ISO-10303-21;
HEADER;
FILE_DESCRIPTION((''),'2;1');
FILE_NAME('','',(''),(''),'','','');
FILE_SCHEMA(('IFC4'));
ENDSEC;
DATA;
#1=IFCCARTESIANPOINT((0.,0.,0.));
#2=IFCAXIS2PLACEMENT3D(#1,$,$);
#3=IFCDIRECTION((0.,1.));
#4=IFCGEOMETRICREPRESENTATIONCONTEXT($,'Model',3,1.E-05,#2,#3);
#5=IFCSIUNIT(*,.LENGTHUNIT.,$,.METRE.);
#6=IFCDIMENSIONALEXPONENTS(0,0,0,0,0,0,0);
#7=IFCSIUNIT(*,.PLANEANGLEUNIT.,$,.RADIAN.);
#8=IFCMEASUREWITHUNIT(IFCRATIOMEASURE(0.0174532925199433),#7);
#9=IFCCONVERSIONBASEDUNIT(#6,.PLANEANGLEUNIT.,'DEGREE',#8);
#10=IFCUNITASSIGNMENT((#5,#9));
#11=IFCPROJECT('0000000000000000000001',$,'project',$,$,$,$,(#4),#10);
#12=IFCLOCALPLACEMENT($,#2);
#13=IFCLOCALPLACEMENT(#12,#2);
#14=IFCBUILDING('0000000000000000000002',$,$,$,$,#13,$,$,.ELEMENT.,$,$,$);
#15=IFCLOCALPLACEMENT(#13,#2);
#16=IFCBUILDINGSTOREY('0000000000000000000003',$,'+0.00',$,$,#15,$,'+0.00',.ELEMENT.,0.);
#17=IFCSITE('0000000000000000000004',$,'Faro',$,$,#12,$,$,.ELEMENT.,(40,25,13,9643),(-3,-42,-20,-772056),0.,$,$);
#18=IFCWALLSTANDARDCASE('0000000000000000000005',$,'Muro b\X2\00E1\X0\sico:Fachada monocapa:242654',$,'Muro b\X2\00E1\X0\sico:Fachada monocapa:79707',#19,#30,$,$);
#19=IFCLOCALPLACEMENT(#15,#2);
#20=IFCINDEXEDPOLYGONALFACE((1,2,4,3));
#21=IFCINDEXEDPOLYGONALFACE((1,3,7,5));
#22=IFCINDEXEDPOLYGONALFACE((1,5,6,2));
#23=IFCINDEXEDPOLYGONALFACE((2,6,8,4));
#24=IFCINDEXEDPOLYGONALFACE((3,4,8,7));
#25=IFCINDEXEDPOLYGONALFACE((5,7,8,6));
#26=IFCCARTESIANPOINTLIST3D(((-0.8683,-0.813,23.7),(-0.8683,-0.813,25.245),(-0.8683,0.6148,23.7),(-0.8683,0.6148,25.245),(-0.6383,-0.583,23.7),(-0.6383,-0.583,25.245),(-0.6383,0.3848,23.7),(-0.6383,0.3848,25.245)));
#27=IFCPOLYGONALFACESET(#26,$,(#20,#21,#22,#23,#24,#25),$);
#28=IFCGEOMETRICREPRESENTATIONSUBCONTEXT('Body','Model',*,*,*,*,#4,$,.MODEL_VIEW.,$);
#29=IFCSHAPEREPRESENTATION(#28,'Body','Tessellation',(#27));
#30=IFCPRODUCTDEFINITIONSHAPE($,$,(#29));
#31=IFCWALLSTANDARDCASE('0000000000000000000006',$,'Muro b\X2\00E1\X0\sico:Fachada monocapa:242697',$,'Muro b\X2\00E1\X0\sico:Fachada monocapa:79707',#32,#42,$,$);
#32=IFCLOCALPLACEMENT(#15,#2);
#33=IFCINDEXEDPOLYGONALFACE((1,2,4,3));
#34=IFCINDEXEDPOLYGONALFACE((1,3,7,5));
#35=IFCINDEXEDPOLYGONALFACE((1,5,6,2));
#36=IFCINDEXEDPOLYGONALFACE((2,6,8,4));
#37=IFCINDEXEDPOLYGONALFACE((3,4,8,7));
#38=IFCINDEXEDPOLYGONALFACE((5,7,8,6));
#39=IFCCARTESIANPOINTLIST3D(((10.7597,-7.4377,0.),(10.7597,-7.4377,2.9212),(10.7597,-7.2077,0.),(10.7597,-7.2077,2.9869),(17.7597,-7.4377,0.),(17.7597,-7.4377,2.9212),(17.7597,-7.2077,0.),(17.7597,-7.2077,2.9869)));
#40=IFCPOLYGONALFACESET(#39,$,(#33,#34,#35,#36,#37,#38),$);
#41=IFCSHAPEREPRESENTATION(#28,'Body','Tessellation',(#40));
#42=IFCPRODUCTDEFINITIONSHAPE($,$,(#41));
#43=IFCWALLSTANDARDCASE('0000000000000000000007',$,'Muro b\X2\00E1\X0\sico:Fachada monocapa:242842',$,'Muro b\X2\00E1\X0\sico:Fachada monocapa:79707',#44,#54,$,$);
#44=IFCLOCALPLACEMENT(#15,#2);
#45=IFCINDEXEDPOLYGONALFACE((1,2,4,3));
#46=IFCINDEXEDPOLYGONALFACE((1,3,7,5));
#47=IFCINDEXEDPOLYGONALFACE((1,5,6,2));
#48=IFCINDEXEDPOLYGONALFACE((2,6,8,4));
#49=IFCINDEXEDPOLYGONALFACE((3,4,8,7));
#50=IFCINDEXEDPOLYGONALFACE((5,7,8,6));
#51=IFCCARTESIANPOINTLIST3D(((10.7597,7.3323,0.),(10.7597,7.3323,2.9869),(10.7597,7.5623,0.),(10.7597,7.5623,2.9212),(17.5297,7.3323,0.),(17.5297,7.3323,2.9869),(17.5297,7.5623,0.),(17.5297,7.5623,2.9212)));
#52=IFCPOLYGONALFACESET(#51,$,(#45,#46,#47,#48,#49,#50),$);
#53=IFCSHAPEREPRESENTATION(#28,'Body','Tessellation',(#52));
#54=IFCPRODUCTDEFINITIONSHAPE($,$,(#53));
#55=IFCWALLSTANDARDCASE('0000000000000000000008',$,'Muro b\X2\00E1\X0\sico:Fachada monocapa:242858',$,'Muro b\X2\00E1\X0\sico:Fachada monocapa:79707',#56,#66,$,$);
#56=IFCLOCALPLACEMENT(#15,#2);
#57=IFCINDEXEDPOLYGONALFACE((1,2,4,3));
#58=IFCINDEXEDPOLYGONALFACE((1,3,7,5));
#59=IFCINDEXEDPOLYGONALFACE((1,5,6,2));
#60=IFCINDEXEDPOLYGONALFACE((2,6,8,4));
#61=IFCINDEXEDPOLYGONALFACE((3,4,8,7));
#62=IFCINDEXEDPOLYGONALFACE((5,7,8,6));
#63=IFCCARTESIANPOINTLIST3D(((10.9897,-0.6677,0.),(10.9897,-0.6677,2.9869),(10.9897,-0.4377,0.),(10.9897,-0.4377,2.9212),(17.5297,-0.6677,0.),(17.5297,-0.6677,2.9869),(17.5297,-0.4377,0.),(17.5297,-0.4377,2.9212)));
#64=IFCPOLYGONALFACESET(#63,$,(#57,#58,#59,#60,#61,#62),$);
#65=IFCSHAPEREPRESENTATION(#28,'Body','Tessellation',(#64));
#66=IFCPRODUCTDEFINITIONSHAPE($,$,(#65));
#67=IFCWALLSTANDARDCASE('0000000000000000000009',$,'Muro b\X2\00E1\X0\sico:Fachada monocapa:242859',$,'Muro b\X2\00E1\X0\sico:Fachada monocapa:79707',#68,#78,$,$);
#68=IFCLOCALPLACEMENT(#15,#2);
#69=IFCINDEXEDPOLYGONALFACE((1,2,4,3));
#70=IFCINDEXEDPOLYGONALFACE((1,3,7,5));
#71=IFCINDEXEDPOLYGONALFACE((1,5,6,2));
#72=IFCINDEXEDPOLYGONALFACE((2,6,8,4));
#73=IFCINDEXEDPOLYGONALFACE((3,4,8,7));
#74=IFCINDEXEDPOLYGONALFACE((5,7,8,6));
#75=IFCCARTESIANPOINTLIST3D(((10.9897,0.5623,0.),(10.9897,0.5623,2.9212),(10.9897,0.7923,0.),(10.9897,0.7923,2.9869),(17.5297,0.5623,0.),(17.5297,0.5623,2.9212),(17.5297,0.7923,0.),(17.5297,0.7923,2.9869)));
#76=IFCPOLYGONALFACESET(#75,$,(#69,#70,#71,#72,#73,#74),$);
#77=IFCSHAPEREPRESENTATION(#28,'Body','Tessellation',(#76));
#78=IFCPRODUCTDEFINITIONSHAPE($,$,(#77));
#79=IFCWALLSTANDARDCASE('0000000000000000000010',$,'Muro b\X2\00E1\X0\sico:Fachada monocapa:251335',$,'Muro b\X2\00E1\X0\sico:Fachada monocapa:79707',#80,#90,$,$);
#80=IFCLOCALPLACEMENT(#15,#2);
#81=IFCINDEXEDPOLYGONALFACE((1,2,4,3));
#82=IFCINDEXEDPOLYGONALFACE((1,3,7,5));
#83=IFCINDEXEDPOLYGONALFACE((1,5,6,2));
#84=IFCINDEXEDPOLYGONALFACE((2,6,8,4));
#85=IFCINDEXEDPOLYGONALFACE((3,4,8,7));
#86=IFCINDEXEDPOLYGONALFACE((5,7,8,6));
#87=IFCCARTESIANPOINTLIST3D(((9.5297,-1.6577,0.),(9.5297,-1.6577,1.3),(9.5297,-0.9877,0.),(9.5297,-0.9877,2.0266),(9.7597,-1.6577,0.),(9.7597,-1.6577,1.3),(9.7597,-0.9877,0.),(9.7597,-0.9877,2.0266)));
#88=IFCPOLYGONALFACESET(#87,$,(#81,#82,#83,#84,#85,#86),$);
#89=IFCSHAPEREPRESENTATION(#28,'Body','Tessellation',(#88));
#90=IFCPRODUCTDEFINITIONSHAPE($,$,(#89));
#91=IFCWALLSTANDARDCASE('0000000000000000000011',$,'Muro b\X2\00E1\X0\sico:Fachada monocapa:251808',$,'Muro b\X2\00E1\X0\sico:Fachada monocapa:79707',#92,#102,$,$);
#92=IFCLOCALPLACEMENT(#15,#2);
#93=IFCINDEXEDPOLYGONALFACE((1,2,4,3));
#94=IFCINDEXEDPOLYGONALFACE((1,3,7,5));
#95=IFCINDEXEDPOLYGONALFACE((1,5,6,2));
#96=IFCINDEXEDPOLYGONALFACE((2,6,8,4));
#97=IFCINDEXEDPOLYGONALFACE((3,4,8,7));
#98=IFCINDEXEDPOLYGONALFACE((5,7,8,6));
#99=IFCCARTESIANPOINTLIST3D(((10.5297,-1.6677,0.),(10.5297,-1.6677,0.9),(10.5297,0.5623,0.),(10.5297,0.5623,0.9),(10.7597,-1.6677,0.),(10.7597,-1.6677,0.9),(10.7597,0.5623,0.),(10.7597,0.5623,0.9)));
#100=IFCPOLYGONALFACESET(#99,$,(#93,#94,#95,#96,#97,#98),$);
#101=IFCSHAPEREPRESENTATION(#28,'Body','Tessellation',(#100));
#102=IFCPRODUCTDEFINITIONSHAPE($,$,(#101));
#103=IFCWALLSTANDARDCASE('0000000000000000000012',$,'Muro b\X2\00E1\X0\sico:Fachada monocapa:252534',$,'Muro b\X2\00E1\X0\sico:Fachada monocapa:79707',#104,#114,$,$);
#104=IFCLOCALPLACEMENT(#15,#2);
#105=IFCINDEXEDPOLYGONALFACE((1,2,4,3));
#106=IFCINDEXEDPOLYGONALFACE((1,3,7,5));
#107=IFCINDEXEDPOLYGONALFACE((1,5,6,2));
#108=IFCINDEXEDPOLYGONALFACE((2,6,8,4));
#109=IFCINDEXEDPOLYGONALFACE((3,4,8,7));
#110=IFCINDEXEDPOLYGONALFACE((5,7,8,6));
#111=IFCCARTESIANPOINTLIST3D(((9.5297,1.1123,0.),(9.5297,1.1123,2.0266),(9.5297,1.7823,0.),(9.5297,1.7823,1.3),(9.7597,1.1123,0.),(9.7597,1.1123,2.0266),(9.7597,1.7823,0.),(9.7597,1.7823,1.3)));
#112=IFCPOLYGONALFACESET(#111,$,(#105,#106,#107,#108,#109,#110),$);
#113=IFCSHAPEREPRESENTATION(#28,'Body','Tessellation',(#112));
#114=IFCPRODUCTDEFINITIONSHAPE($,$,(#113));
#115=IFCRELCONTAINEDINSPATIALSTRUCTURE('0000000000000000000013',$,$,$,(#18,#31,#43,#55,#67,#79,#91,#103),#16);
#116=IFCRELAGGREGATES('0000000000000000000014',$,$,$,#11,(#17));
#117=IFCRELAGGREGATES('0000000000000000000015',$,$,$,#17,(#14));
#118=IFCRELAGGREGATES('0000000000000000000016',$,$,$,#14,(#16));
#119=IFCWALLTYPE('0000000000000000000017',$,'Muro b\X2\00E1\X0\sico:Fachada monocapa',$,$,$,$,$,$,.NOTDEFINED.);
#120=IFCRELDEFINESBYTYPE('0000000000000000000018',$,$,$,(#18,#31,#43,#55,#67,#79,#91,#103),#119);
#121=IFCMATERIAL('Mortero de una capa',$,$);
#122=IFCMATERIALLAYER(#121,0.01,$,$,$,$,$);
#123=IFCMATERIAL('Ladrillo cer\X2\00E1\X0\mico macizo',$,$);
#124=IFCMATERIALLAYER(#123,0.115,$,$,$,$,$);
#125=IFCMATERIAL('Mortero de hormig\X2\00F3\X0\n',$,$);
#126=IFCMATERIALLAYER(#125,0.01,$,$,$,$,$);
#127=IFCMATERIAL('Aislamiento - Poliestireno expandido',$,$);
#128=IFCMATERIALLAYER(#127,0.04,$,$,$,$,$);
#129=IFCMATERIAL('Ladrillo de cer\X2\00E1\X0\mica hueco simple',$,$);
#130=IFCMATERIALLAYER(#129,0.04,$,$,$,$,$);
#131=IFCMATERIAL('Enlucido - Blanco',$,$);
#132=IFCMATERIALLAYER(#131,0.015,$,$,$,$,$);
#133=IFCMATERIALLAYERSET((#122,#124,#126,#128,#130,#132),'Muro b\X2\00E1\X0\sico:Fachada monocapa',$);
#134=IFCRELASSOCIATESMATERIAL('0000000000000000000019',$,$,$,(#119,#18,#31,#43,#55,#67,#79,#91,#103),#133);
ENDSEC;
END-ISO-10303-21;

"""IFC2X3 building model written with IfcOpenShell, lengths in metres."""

from ifc_helpers import new_model, entity, si_unit, converted_unit, direction, frame, frame_2d, origin, place, context, subcontext, project, spatial, polyline, rectangle, outline, extrude, clip, halfspace, bounded_halfspace, material, layer, layer_set, layer_usage, type_object, element, save


model = new_model("IFC2X3")

# Units and contexts
model_context = context("Model", 3, precision=1e-05, world=origin(), true_north=direction((0.0, 1.0)))
body_context = subcontext(model_context, "Body", "Model", "MODEL_VIEW")
ifc_project = project(units=[si_unit("LENGTHUNIT", "METRE"), converted_unit("PLANEANGLEUNIT", "DEGREE", entity("IfcRatioMeasure", 0.0174532925199433), si_unit("PLANEANGLEUNIT", "RADIAN"), dimensions=[0, 0, 0, 0, 0, 0, 0])], contexts=[model_context])

# Site, building, storey
site_placement = place(None, origin())
site = spatial("IfcSite", under=ifc_project, at=site_placement, Name="Faro", CompositionType="ELEMENT", RefLatitude=(40, 25, 13, 9643), RefLongitude=(-3, -42, -20, -772056), RefElevation=0.0)
building_placement = place(site_placement, origin())
building = spatial("IfcBuilding", under=site, at=building_placement, CompositionType="ELEMENT")
storey_placement = place(building_placement, origin())
storey = spatial("IfcBuildingStorey", under=building, at=storey_placement, Name="+0.00", LongName="+0.00", CompositionType="ELEMENT", Elevation=0.0)

# Shared definitions
ifc_material_1 = material(Name="Mortero de una capa")
ifc_layer_1 = layer(ifc_material_1, 0.01)
ifc_material_2 = material(Name="Ladrillo cerámico macizo")
ifc_layer_2 = layer(ifc_material_2, 0.115)
ifc_material_3 = material(Name="Mortero de hormigón")
ifc_layer_3 = layer(ifc_material_3, 0.01)
ifc_material_4 = material(Name="Aislamiento - Poliestireno expandido")
ifc_layer_4 = layer(ifc_material_4, 0.04)
ifc_material_5 = material(Name="Ladrillo de cerámica hueco simple")
ifc_layer_5 = layer(ifc_material_5, 0.04)
ifc_material_6 = material(Name="Enlucido - Blanco")
ifc_layer_6 = layer(ifc_material_6, 0.015)
ifc_layer_set = layer_set([ifc_layer_1, ifc_layer_2, ifc_layer_3, ifc_layer_4, ifc_layer_5, ifc_layer_6], Name="Muro básico:Fachada monocapa")
wall_type = type_object("IfcWallType", Name="Muro básico:Fachada monocapa", PredefinedType="NOTDEFINED", material=ifc_layer_set)

# Walls
ifc_layer_usage_1 = layer_usage(ifc_layer_set, "AXIS2", "POSITIVE", -0.115)
wall_1_placement = place(storey_placement, frame((-0.7533, -0.813, 23.7), z_axis=(0.0, 0.0, 1.0), x_axis=(0.0, 1.0, 0.0)))
element("IfcWallStandardCase", 1, at=wall_1_placement, inside=storey, type_object=wall_type, material=ifc_layer_usage_1, Name="Muro básico:Fachada monocapa:242654", ObjectType="Muro básico:Fachada monocapa:79707", context=body_context, shape_type="Clipping", body=[
    clip(extrude(outline(polyline([(1.1978, -0.115), (1.4278, 0.115), (0.3253, 0.115), (0.0, 0.115), (0.23, -0.115), (1.1978, -0.115)])), origin(), (0.0, 0.0, 1.0), 1.545), bounded_halfspace(frame((0.23, -0.115, 1.545), z_axis=(0.0, 0.0, 1.0), x_axis=(0.0, 1.0, 0.0)), False, frame((0.23, -0.115, 1.545), z_axis=(0.0, 0.0, 1.0), x_axis=(0.0, 1.0, 0.0)), polyline([(0.0, 0.0), (0.0, -0.9678), (0.23, -1.1979), (0.23, -0.0953), (0.23, 0.23), (0.0, 0.0)]))),
])
ifc_layer_usage_2 = layer_usage(ifc_layer_set, "AXIS2", "POSITIVE", -0.115)
wall_2_placement = place(storey_placement, frame((10.7597, -7.3227, 0.0)))
element("IfcWallStandardCase", 2, at=wall_2_placement, inside=storey, type_object=wall_type, material=ifc_layer_usage_2, Name="Muro básico:Fachada monocapa:242697", ObjectType="Muro básico:Fachada monocapa:79707", context=body_context, shape_type="Clipping", body=[
    clip(extrude(rectangle(XDim=7.0, YDim=0.23, at=frame_2d((3.5, 0.0), x_axis=(-1.0, 0.0))), origin(), (0.0, 0.0, 1.0), 2.9869), bounded_halfspace(frame((0.0, -0.115, 2.9212), z_axis=(0.0, -0.274721, 0.961524), x_axis=(0.0, -0.961524, -0.274721)), False, frame((0.0, -0.115, 2.9212), z_axis=(0.0, -0.274721, 0.961524), x_axis=(0.0, -0.961524, -0.274721)), polyline([(0.0, 0.0), (0.0, 7.0), (-0.2392, 7.0), (-0.2392, 0.0), (0.0, 0.0)]))),
])
ifc_layer_usage_3 = layer_usage(ifc_layer_set, "AXIS2", "POSITIVE", -0.115)
wall_3_placement = place(storey_placement, frame((17.5297, 7.4473, 0.0), z_axis=(0.0, 0.0, 1.0), x_axis=(-1.0, 0.0, 0.0)))
element("IfcWallStandardCase", 3, at=wall_3_placement, inside=storey, type_object=wall_type, material=ifc_layer_usage_3, Name="Muro básico:Fachada monocapa:242842", ObjectType="Muro básico:Fachada monocapa:79707", context=body_context, shape_type="Clipping", body=[
    clip(extrude(rectangle(XDim=6.77, YDim=0.23, at=frame_2d((3.385, 0.0), x_axis=(-1.0, 0.0))), origin(), (0.0, 0.0, 1.0), 2.9869), bounded_halfspace(frame((0.0, -0.115, 2.9212), z_axis=(0.0, -0.274721, 0.961524), x_axis=(-1.0, 0.0, 0.0)), False, frame((0.0, -0.115, 2.9212), z_axis=(0.0, -0.274721, 0.961524), x_axis=(-1.0, 0.0, 0.0)), polyline([(0.0, 0.0), (-6.77, 0.0), (-6.77, -0.2392), (0.0, -0.2392), (0.0, 0.0)]))),
])
ifc_layer_usage_4 = layer_usage(ifc_layer_set, "AXIS2", "POSITIVE", -0.115)
wall_4_placement = place(storey_placement, frame((17.5297, -0.5527, 0.0), z_axis=(0.0, 0.0, 1.0), x_axis=(-1.0, 0.0, 0.0)))
element("IfcWallStandardCase", 4, at=wall_4_placement, inside=storey, type_object=wall_type, material=ifc_layer_usage_4, Name="Muro básico:Fachada monocapa:242858", ObjectType="Muro básico:Fachada monocapa:79707", context=body_context, shape_type="Clipping", body=[
    clip(extrude(rectangle(XDim=6.54, YDim=0.23, at=frame_2d((3.27, 0.0), x_axis=(-1.0, 0.0))), origin(), (0.0, 0.0, 1.0), 2.9869), bounded_halfspace(frame((0.0, -0.115, 2.9212), z_axis=(0.0, -0.274721, 0.961524), x_axis=(-1.0, 0.0, 0.0)), False, frame((0.0, -0.115, 2.9212), z_axis=(0.0, -0.274721, 0.961524), x_axis=(-1.0, 0.0, 0.0)), polyline([(0.0, 0.0), (-6.54, 0.0), (-6.54, -0.2392), (0.0, -0.2392), (0.0, 0.0)]))),
])
ifc_layer_usage_5 = layer_usage(ifc_layer_set, "AXIS2", "POSITIVE", -0.115)
wall_5_placement = place(storey_placement, frame((10.9897, 0.6773, 0.0)))
element("IfcWallStandardCase", 5, at=wall_5_placement, inside=storey, type_object=wall_type, material=ifc_layer_usage_5, Name="Muro básico:Fachada monocapa:242859", ObjectType="Muro básico:Fachada monocapa:79707", context=body_context, shape_type="Clipping", body=[
    clip(extrude(rectangle(XDim=6.54, YDim=0.23, at=frame_2d((3.27, 0.0), x_axis=(-1.0, 0.0))), origin(), (0.0, 0.0, 1.0), 2.9869), bounded_halfspace(frame((0.0, -0.115, 2.9212), z_axis=(0.0, -0.274721, 0.961524), x_axis=(0.0, -0.961524, -0.274721)), False, frame((0.0, -0.115, 2.9212), z_axis=(0.0, -0.274721, 0.961524), x_axis=(0.0, -0.961524, -0.274721)), polyline([(0.0, 0.0), (0.0, 6.54), (-0.2392, 6.54), (-0.2392, 0.0), (0.0, 0.0)]))),
])
ifc_layer_usage_6 = layer_usage(ifc_layer_set, "AXIS2", "POSITIVE", -0.115)
wall_6_placement = place(storey_placement, frame((9.6447, -0.9877, 0.0), z_axis=(0.0, 0.0, 1.0), x_axis=(0.0, -1.0, 0.0)))
element("IfcWallStandardCase", 6, at=wall_6_placement, inside=storey, type_object=wall_type, material=ifc_layer_usage_6, Name="Muro básico:Fachada monocapa:251335", ObjectType="Muro básico:Fachada monocapa:79707", context=body_context, shape_type="Clipping", body=[
    clip(extrude(rectangle(XDim=0.67, YDim=0.23, at=frame_2d((0.335, 0.0), x_axis=(-1.0, 0.0))), origin(), (0.0, 0.0, 1.0), 2.0266), halfspace(frame((0.0, -0.115, 2.0266), z_axis=(0.735165, 0.0, 0.677888), x_axis=(0.0, 1.0, 0.0)), False)),
])
ifc_layer_usage_7 = layer_usage(ifc_layer_set, "AXIS2", "POSITIVE", -0.115)
wall_7_placement = place(storey_placement, frame((10.6447, -0.4377, 0.0), z_axis=(0.0, 0.0, 1.0), x_axis=(0.0, 1.0, 0.0)))
element("IfcWallStandardCase", 7, at=wall_7_placement, inside=storey, type_object=wall_type, material=ifc_layer_usage_7, Name="Muro básico:Fachada monocapa:251808", ObjectType="Muro básico:Fachada monocapa:79707", context=body_context, shape_type="Clipping", body=[
    clip(extrude(rectangle(XDim=0.23, YDim=2.23, at=frame_2d((-0.115, 0.0), x_axis=(0.0, -1.0))), origin(), (0.0, 0.0, 1.0), 0.9), bounded_halfspace(frame((0.0, -0.115, 0.9), z_axis=(0.0, 0.0, -1.0), x_axis=(-1.0, 0.0, 0.0)), True, frame((0.0, -0.115, 0.9), z_axis=(0.0, 0.0, -1.0), x_axis=(-1.0, 0.0, 0.0)), polyline([(0.0, 0.0), (0.0, 0.23), (-1.0, 0.23), (-1.0, 0.0), (0.0, 0.0)]))),
])
ifc_layer_usage_8 = layer_usage(ifc_layer_set, "AXIS2", "POSITIVE", -0.115)
wall_8_placement = place(storey_placement, frame((9.6447, 1.1123, 0.0), z_axis=(0.0, 0.0, 1.0), x_axis=(0.0, 1.0, 0.0)))
element("IfcWallStandardCase", 8, at=wall_8_placement, inside=storey, type_object=wall_type, material=ifc_layer_usage_8, Name="Muro básico:Fachada monocapa:252534", ObjectType="Muro básico:Fachada monocapa:79707", context=body_context, shape_type="Clipping", body=[
    clip(extrude(rectangle(XDim=0.67, YDim=0.23, at=frame_2d((0.335, 0.0), x_axis=(-1.0, 0.0))), origin(), (0.0, 0.0, 1.0), 2.0266), halfspace(frame((0.0, -0.115, 2.0266), z_axis=(0.735165, 0.0, 0.677888), x_axis=(0.0, 1.0, 0.0)), False)),
])

save(model, "model.ifc")
